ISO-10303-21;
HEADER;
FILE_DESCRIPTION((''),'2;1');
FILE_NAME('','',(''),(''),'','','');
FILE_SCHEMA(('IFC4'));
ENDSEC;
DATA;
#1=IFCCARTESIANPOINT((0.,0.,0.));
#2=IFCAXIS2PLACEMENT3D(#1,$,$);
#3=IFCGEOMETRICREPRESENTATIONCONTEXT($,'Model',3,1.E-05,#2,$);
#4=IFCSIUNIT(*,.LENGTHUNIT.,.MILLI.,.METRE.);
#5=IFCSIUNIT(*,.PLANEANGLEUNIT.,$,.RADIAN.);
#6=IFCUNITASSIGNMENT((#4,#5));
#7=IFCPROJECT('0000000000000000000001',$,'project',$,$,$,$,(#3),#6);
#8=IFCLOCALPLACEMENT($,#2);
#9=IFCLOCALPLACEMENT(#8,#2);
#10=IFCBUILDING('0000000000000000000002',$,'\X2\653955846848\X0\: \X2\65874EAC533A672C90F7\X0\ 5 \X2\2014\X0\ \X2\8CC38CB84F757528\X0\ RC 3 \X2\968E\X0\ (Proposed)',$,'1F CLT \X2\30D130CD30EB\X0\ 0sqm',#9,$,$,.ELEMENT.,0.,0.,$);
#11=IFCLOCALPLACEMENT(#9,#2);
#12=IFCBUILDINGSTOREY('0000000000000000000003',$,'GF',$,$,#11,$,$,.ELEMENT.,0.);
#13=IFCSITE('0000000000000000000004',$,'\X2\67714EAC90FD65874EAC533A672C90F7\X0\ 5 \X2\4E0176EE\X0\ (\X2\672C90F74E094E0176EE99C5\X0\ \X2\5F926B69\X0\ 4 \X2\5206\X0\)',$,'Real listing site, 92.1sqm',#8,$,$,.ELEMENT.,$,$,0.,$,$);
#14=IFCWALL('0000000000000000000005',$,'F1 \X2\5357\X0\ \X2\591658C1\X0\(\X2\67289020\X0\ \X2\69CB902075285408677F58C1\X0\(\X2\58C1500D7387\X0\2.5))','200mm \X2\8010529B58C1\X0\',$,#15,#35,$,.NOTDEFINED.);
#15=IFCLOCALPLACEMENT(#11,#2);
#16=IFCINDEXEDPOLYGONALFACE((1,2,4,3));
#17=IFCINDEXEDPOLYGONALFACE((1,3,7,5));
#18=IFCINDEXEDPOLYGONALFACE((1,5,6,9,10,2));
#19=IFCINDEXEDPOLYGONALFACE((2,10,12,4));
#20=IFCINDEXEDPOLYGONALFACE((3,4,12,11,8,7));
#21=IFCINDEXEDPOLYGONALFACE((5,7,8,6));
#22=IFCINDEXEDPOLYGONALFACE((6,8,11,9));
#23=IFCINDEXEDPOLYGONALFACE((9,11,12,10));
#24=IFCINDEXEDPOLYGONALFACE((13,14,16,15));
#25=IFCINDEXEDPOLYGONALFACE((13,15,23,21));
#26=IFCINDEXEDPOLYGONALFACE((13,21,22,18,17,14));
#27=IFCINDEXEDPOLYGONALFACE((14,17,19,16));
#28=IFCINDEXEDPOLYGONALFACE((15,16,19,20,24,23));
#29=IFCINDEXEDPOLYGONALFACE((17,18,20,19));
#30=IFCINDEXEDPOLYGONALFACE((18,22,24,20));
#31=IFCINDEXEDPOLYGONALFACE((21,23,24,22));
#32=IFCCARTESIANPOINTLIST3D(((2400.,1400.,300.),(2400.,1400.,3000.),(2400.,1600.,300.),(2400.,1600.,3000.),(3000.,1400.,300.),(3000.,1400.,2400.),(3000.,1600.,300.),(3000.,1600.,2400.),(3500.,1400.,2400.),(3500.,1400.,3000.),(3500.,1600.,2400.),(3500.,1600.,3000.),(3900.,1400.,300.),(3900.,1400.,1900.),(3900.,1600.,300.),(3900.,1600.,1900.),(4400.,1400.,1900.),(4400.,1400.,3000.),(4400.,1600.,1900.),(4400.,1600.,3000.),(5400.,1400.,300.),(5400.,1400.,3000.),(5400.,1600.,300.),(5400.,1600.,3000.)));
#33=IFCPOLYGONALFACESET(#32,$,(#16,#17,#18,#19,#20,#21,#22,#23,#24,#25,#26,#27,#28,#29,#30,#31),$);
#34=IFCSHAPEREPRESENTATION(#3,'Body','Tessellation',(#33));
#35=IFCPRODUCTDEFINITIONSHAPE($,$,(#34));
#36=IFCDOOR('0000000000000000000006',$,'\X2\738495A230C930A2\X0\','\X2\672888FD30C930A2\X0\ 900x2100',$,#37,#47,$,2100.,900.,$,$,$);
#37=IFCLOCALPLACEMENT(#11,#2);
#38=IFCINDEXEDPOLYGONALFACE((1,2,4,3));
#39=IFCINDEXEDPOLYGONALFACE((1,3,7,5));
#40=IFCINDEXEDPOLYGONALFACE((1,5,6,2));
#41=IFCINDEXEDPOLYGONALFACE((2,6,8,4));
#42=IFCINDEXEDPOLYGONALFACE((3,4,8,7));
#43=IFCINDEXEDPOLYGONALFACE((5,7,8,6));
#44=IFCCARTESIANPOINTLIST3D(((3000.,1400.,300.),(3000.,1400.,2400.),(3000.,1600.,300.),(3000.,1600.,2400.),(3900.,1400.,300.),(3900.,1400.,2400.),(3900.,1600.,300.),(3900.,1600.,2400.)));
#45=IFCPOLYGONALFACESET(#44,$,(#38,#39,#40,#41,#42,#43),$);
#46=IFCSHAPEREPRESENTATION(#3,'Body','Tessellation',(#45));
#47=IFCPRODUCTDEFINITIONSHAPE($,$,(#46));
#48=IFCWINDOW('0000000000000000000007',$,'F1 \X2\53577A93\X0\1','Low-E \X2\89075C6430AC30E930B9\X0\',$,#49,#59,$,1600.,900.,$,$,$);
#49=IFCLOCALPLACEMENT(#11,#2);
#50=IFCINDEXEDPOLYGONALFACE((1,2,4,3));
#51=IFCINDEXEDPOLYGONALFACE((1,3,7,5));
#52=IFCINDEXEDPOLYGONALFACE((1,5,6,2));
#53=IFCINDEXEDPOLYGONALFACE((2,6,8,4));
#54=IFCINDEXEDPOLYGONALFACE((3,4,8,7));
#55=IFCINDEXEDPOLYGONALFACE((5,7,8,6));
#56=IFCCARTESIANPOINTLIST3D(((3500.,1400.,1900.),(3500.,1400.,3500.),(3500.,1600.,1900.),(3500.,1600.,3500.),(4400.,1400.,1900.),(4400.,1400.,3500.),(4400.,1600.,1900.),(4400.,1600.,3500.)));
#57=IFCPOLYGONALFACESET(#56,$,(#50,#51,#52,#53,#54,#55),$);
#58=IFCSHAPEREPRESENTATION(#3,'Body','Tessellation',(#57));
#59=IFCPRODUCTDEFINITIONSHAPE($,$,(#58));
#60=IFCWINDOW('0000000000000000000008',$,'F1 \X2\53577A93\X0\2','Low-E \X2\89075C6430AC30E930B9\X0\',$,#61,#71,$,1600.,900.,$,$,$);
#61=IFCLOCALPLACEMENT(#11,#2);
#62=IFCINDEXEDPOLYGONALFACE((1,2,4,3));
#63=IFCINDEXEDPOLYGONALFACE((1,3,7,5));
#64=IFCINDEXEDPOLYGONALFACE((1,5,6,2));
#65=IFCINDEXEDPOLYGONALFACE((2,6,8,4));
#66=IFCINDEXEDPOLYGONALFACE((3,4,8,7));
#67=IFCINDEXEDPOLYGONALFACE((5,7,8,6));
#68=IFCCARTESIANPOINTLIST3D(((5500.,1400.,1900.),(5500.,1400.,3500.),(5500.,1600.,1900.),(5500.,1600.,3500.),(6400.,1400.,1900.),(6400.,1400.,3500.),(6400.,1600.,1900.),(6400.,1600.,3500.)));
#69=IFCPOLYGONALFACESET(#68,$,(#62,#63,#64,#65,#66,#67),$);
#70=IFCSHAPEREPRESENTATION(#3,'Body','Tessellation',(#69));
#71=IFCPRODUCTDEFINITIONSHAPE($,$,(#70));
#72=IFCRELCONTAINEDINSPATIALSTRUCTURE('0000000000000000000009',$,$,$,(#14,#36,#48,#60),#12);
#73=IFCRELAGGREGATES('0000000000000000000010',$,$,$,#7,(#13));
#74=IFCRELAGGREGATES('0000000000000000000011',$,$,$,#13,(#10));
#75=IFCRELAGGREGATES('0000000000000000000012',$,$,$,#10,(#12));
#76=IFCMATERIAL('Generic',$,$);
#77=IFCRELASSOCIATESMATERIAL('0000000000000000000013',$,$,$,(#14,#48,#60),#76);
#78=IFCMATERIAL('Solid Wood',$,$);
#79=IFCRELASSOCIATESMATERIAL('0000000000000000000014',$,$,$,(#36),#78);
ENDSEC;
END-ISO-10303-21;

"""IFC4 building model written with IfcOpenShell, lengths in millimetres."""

from ifc_helpers import new_model, si_unit, frame, frame_2d, origin, place, context, project, spatial, rectangle, extrude, material, element, fill, save


model = new_model("IFC4")

# Units and contexts
model_context = context("Model", 3, precision=1e-05, world=origin())
ifc_project = project(units=[si_unit("LENGTHUNIT", "METRE", prefix="MILLI"), si_unit("PLANEANGLEUNIT", "RADIAN")], contexts=[model_context])

# Site, building, storey
site_placement = place(None, origin())
site = spatial("IfcSite", under=ifc_project, at=site_placement, Name="東京都文京区本郷 5 丁目 (本郷三丁目駅 徒歩 4 分)", ObjectType="Real listing site, 92.1sqm", CompositionType="ELEMENT", RefElevation=0.0)
building_placement = place(site_placement, origin())
building = spatial("IfcBuilding", under=site, at=building_placement, Name="改善案: 文京区本郷 5 — 賃貸併用 RC 3 階 (Proposed)", ObjectType="1F CLT パネル 0sqm", CompositionType="ELEMENT", ElevationOfRefHeight=0.0, ElevationOfTerrain=0.0)
storey_placement = place(building_placement, origin())
storey = spatial("IfcBuildingStorey", under=building, at=storey_placement, Name="GF", CompositionType="ELEMENT", Elevation=0.0)

# Shared definitions
ifc_material_1 = material(Name="Generic")

# Wall, openings, door, windows
wall_1_placement = place(storey_placement, frame((1200.0, 700.0, 150.0)))
wall_1 = element("IfcWall", 1, at=wall_1_placement, inside=storey, material=ifc_material_1, Name="F1 南 外壁(木造 構造用合板壁(壁倍率2.5))", Description="200mm 耐力壁", PredefinedType="NOTDEFINED", context=model_context, shape_type="SweptSolid", body=[
    extrude(rectangle(XDim=3000.0, YDim=200.0, at=frame_2d((1500.0, 100.0))), frame((1200.0, 700.0, 150.0)), (0.0, 0.0, 1.0), 2700.0),
])
opening_1_placement = place(storey_placement, frame((1500.0, 700.0, 150.0)))
opening_1 = element("IfcOpeningElement", 2, at=opening_1_placement, cuts=wall_1, PredefinedType="NOTDEFINED", context=model_context, shape_type="SweptSolid", body=[
    extrude(rectangle(XDim=900.0, YDim=200.0, at=frame_2d((450.0, 100.0))), frame((1500.0, 700.0, 150.0)), (0.0, 0.0, 1.0), 2100.0),
])
opening_2_placement = place(storey_placement, frame((1750.0, 700.0, 950.0)))
opening_2 = element("IfcOpeningElement", 3, at=opening_2_placement, cuts=wall_1, PredefinedType="NOTDEFINED", context=model_context, shape_type="SweptSolid", body=[
    extrude(rectangle(XDim=900.0, YDim=200.0, at=frame_2d((450.0, 100.0))), frame((1750.0, 700.0, 950.0)), (0.0, 0.0, 1.0), 1600.0),
])
opening_3_placement = place(storey_placement, frame((2750.0, 700.0, 950.0)))
opening_3 = element("IfcOpeningElement", 4, at=opening_3_placement, cuts=wall_1, PredefinedType="NOTDEFINED", context=model_context, shape_type="SweptSolid", body=[
    extrude(rectangle(XDim=900.0, YDim=200.0, at=frame_2d((450.0, 100.0))), frame((2750.0, 700.0, 950.0)), (0.0, 0.0, 1.0), 1600.0),
])
ifc_material_2 = material(Name="Solid Wood")
door_placement = place(storey_placement, frame((1500.0, 700.0, 150.0)))
door = element("IfcDoor", 5, at=door_placement, inside=storey, material=ifc_material_2, Name="玄関ドア", Description="木製ドア 900x2100", OverallHeight=2100.0, OverallWidth=900.0, context=model_context, shape_type="SweptSolid", body=[
    extrude(rectangle(XDim=900.0, YDim=200.0, at=frame_2d((450.0, 100.0))), frame((1500.0, 700.0, 150.0)), (0.0, 0.0, 1.0), 2100.0),
])
fill(opening_1, door)
window_1_placement = place(storey_placement, frame((1750.0, 700.0, 950.0)))
window_1 = element("IfcWindow", 6, at=window_1_placement, inside=storey, material=ifc_material_1, Name="F1 南窓1", Description="Low-E 複層ガラス", OverallHeight=1600.0, OverallWidth=900.0, context=model_context, shape_type="SweptSolid", body=[
    extrude(rectangle(XDim=900.0, YDim=200.0, at=frame_2d((450.0, 100.0))), frame((1750.0, 700.0, 950.0)), (0.0, 0.0, 1.0), 1600.0),
])
fill(opening_2, window_1)
window_2_placement = place(storey_placement, frame((2750.0, 700.0, 950.0)))
window_2 = element("IfcWindow", 7, at=window_2_placement, inside=storey, material=ifc_material_1, Name="F1 南窓2", Description="Low-E 複層ガラス", OverallHeight=1600.0, OverallWidth=900.0, context=model_context, shape_type="SweptSolid", body=[
    extrude(rectangle(XDim=900.0, YDim=200.0, at=frame_2d((450.0, 100.0))), frame((2750.0, 700.0, 950.0)), (0.0, 0.0, 1.0), 1600.0),
])
fill(opening_3, window_2)

save(model, "model.ifc")
